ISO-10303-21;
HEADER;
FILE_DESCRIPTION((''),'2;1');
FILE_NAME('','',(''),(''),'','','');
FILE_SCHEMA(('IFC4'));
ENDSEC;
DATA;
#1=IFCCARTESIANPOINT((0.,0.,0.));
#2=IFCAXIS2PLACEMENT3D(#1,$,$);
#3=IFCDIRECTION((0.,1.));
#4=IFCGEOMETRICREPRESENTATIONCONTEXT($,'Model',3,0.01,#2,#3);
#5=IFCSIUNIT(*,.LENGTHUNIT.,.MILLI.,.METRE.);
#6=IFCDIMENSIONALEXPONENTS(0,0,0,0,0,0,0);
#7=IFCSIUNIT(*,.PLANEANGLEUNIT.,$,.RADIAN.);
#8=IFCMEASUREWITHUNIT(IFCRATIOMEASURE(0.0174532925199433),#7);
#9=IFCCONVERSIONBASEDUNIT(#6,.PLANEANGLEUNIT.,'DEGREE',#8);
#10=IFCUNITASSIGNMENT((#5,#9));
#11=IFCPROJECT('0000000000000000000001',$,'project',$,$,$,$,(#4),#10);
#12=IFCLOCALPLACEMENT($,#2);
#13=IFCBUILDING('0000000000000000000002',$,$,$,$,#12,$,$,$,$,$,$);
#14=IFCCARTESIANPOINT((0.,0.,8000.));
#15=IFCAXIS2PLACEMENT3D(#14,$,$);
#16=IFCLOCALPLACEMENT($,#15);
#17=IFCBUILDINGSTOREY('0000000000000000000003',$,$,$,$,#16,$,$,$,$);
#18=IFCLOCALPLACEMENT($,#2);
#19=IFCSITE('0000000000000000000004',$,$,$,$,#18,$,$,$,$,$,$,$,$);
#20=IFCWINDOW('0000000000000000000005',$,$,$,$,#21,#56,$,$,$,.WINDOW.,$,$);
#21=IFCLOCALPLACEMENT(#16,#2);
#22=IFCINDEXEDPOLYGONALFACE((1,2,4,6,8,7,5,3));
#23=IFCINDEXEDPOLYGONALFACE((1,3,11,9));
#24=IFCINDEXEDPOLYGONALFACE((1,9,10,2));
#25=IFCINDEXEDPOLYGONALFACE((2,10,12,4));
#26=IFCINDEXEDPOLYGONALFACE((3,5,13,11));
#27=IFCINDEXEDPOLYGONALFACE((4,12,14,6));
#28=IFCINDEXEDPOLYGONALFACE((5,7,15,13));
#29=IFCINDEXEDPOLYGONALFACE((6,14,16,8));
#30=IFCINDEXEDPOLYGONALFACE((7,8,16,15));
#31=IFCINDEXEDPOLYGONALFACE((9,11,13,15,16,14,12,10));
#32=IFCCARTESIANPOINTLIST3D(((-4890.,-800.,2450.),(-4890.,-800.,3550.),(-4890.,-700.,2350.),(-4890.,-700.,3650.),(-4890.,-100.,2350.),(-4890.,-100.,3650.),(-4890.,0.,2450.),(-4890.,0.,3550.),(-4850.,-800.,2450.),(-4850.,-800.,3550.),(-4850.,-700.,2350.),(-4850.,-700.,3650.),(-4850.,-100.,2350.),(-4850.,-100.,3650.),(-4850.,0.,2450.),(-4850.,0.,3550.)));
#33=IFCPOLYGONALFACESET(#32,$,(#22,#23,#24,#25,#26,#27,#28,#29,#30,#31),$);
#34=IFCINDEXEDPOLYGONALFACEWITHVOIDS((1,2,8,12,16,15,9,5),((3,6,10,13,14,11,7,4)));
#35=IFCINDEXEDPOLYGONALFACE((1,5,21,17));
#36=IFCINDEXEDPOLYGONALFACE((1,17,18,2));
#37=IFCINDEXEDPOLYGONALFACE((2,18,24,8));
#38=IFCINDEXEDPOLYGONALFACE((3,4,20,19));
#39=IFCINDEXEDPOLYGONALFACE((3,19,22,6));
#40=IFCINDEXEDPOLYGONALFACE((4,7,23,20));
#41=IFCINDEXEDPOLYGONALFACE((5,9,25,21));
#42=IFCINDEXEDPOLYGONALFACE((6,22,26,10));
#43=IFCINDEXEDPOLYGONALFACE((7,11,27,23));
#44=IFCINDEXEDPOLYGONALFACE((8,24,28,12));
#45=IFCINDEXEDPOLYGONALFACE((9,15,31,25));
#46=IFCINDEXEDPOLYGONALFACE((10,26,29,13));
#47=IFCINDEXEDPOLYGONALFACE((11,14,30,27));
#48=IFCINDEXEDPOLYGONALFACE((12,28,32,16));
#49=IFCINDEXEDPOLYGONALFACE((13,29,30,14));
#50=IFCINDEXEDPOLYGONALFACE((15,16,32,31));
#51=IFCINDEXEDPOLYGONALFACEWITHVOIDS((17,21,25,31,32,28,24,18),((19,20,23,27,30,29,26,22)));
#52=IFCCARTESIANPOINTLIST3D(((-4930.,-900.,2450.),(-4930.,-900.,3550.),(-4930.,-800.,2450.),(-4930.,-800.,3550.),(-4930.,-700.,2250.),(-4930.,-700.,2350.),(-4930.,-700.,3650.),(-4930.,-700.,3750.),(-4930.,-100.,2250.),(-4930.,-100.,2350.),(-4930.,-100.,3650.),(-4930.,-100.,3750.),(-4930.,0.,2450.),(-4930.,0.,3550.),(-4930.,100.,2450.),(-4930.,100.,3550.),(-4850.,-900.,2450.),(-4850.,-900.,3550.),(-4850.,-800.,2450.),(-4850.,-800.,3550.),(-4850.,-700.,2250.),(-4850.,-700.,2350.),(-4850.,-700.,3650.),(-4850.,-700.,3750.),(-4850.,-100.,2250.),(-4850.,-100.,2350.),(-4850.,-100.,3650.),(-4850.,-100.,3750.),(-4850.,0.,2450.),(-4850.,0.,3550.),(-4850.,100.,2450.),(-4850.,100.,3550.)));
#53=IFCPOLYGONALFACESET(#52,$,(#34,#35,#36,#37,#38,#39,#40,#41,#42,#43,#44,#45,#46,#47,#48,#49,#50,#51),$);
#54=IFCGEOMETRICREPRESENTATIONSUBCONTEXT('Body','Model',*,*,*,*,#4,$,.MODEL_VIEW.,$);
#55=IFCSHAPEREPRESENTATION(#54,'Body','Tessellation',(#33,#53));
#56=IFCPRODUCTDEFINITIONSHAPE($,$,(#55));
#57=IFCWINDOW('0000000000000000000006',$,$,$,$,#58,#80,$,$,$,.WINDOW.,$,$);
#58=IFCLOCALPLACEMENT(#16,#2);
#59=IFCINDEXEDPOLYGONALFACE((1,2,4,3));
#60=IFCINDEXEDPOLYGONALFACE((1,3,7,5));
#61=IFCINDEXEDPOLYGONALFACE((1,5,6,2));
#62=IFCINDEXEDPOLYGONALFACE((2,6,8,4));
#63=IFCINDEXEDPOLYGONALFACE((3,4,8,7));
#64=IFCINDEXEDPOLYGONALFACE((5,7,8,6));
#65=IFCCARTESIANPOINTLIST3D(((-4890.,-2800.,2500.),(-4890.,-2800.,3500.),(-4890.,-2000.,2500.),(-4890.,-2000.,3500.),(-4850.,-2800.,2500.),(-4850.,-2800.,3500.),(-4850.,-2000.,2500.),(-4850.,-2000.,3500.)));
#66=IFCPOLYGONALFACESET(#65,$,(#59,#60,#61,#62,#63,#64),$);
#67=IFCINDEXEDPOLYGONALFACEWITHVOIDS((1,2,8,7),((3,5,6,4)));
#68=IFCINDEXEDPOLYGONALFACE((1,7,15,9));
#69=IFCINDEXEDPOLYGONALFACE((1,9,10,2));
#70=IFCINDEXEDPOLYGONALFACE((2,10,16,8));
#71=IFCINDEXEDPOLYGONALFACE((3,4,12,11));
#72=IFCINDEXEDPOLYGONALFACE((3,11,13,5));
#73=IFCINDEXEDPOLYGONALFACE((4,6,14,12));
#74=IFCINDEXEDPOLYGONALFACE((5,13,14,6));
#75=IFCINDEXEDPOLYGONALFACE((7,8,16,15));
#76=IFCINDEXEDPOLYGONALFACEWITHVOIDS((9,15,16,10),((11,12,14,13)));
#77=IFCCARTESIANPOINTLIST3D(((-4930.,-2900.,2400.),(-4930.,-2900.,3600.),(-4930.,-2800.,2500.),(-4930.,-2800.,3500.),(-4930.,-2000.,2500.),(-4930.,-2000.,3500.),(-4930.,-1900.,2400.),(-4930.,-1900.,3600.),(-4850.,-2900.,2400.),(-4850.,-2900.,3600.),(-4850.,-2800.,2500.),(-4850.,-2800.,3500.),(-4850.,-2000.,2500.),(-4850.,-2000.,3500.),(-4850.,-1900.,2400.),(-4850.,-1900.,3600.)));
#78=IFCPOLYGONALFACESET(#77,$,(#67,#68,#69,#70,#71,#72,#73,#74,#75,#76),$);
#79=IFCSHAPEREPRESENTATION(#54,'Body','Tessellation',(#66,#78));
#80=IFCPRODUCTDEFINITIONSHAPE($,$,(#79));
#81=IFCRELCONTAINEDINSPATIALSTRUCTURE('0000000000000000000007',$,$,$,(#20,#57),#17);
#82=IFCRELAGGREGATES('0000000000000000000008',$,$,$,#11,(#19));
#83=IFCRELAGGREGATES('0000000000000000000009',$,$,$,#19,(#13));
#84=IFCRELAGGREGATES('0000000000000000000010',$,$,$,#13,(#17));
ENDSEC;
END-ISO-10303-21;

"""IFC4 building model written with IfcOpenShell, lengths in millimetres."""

from ifc_helpers import new_model, entity, si_unit, converted_unit, direction, frame, origin, place, context, subcontext, project, spatial, element, save


model = new_model("IFC4")

# Units and contexts
model_context = context("Model", 3, precision=0.01, world=origin(), true_north=direction((0.0, 1.0)))
body_context = subcontext(model_context, "Body", "Model", "MODEL_VIEW")
ifc_project = project(units=[si_unit("LENGTHUNIT", "METRE", prefix="MILLI"), converted_unit("PLANEANGLEUNIT", "DEGREE", entity("IfcRatioMeasure", 0.0174532925199433), si_unit("PLANEANGLEUNIT", "RADIAN"), dimensions=[0, 0, 0, 0, 0, 0, 0])], contexts=[model_context])

# Site, building, storey
site_placement = place(None, origin())
site = spatial("IfcSite", under=ifc_project, at=site_placement)
building_placement = place(None, origin())
building = spatial("IfcBuilding", under=site, at=building_placement)
storey_placement = place(None, frame((0.0, 0.0, 8000.0)))
storey = spatial("IfcBuildingStorey", under=building, at=storey_placement)

# Shared definitions
cartesian_point_1 = entity("IfcCartesianPoint", [-400.0, -550.0])
shared_polyline_1 = entity("IfcPolyline", [cartesian_point_1, entity("IfcCartesianPoint", [-400.0, 550.0]), entity("IfcCartesianPoint", [-300.0, 650.0]), entity("IfcCartesianPoint", [300.0, 650.0]), entity("IfcCartesianPoint", [400.0, 550.0]), entity("IfcCartesianPoint", [400.0, -550.0]), entity("IfcCartesianPoint", [300.0, -650.0]), entity("IfcCartesianPoint", [-300.0, -650.0]), cartesian_point_1])
cartesian_point_2 = entity("IfcCartesianPoint", [-400.0, -500.0])
shared_polyline_2 = entity("IfcPolyline", [cartesian_point_2, entity("IfcCartesianPoint", [-400.0, 500.0]), entity("IfcCartesianPoint", [-400.0, 500.0]), entity("IfcCartesianPoint", [400.0, 500.0]), entity("IfcCartesianPoint", [400.0, 500.0]), entity("IfcCartesianPoint", [400.0, -500.0]), entity("IfcCartesianPoint", [400.0, -500.0]), entity("IfcCartesianPoint", [-400.0, -500.0]), cartesian_point_2])

# Shared definitions
wall_1_placement = place(storey_placement, frame((-4900.0, 100.0, 0.0), z_axis=(0.0, 0.0, 1.0), x_axis=(0.0, -1.0, 0.0)))
window_1_placement = place(wall_1_placement, frame((500.0, 50.0, 3000.0)))
window_2_placement = place(wall_1_placement, frame((2500.0, 50.0, 3000.0)))

# Windows
cartesian_point_3 = entity("IfcCartesianPoint", [-500.0, -550.0])
element("IfcWindow", 1, at=window_1_placement, inside=storey, PredefinedType="WINDOW", context=body_context, shape_type="SweptSolid", body=[
    entity("IfcExtrudedAreaSolid", entity("IfcArbitraryClosedProfileDef", "AREA", None, shared_polyline_1), entity("IfcAxis2Placement3D", entity("IfcCartesianPoint", [0.0, 0.0, 0.0]), entity("IfcDirection", [0.0, -1.0, 0.0]), entity("IfcDirection", [1.0, 0.0, 0.0])), entity("IfcDirection", [0.0, 0.0, 1.0]), 40.0),
    entity("IfcExtrudedAreaSolid", entity("IfcArbitraryProfileDefWithVoids", "AREA", None, entity("IfcPolyline", [cartesian_point_3, entity("IfcCartesianPoint", [-500.0, 550.0]), entity("IfcCartesianPoint", [-300.0, 750.0]), entity("IfcCartesianPoint", [300.0, 750.0]), entity("IfcCartesianPoint", [500.0, 550.0]), entity("IfcCartesianPoint", [500.0, -550.0]), entity("IfcCartesianPoint", [300.0, -750.0]), entity("IfcCartesianPoint", [-300.0, -750.0]), cartesian_point_3]), [shared_polyline_1]), entity("IfcAxis2Placement3D", entity("IfcCartesianPoint", [0.0, 0.0, 0.0]), entity("IfcDirection", [0.0, -1.0, 0.0]), entity("IfcDirection", [1.0, 0.0, 0.0])), entity("IfcDirection", [0.0, 0.0, 1.0]), 80.0),
])
cartesian_point_4 = entity("IfcCartesianPoint", [-500.0, -600.0])
element("IfcWindow", 2, at=window_2_placement, inside=storey, PredefinedType="WINDOW", context=body_context, shape_type="SweptSolid", body=[
    entity("IfcExtrudedAreaSolid", entity("IfcArbitraryClosedProfileDef", "AREA", None, shared_polyline_2), entity("IfcAxis2Placement3D", entity("IfcCartesianPoint", [0.0, 0.0, 0.0]), entity("IfcDirection", [0.0, -1.0, 0.0]), entity("IfcDirection", [1.0, 0.0, 0.0])), entity("IfcDirection", [0.0, 0.0, 1.0]), 40.0),
    entity("IfcExtrudedAreaSolid", entity("IfcArbitraryProfileDefWithVoids", "AREA", None, entity("IfcPolyline", [cartesian_point_4, entity("IfcCartesianPoint", [-500.0, 600.0]), entity("IfcCartesianPoint", [-500.0, 600.0]), entity("IfcCartesianPoint", [500.0, 600.0]), entity("IfcCartesianPoint", [500.0, 600.0]), entity("IfcCartesianPoint", [500.0, -600.0]), entity("IfcCartesianPoint", [500.0, -600.0]), entity("IfcCartesianPoint", [-500.0, -600.0]), cartesian_point_4]), [shared_polyline_2]), entity("IfcAxis2Placement3D", entity("IfcCartesianPoint", [0.0, 0.0, 0.0]), entity("IfcDirection", [0.0, -1.0, 0.0]), entity("IfcDirection", [1.0, 0.0, 0.0])), entity("IfcDirection", [0.0, 0.0, 1.0]), 80.0),
])

save(model, "model.ifc")
